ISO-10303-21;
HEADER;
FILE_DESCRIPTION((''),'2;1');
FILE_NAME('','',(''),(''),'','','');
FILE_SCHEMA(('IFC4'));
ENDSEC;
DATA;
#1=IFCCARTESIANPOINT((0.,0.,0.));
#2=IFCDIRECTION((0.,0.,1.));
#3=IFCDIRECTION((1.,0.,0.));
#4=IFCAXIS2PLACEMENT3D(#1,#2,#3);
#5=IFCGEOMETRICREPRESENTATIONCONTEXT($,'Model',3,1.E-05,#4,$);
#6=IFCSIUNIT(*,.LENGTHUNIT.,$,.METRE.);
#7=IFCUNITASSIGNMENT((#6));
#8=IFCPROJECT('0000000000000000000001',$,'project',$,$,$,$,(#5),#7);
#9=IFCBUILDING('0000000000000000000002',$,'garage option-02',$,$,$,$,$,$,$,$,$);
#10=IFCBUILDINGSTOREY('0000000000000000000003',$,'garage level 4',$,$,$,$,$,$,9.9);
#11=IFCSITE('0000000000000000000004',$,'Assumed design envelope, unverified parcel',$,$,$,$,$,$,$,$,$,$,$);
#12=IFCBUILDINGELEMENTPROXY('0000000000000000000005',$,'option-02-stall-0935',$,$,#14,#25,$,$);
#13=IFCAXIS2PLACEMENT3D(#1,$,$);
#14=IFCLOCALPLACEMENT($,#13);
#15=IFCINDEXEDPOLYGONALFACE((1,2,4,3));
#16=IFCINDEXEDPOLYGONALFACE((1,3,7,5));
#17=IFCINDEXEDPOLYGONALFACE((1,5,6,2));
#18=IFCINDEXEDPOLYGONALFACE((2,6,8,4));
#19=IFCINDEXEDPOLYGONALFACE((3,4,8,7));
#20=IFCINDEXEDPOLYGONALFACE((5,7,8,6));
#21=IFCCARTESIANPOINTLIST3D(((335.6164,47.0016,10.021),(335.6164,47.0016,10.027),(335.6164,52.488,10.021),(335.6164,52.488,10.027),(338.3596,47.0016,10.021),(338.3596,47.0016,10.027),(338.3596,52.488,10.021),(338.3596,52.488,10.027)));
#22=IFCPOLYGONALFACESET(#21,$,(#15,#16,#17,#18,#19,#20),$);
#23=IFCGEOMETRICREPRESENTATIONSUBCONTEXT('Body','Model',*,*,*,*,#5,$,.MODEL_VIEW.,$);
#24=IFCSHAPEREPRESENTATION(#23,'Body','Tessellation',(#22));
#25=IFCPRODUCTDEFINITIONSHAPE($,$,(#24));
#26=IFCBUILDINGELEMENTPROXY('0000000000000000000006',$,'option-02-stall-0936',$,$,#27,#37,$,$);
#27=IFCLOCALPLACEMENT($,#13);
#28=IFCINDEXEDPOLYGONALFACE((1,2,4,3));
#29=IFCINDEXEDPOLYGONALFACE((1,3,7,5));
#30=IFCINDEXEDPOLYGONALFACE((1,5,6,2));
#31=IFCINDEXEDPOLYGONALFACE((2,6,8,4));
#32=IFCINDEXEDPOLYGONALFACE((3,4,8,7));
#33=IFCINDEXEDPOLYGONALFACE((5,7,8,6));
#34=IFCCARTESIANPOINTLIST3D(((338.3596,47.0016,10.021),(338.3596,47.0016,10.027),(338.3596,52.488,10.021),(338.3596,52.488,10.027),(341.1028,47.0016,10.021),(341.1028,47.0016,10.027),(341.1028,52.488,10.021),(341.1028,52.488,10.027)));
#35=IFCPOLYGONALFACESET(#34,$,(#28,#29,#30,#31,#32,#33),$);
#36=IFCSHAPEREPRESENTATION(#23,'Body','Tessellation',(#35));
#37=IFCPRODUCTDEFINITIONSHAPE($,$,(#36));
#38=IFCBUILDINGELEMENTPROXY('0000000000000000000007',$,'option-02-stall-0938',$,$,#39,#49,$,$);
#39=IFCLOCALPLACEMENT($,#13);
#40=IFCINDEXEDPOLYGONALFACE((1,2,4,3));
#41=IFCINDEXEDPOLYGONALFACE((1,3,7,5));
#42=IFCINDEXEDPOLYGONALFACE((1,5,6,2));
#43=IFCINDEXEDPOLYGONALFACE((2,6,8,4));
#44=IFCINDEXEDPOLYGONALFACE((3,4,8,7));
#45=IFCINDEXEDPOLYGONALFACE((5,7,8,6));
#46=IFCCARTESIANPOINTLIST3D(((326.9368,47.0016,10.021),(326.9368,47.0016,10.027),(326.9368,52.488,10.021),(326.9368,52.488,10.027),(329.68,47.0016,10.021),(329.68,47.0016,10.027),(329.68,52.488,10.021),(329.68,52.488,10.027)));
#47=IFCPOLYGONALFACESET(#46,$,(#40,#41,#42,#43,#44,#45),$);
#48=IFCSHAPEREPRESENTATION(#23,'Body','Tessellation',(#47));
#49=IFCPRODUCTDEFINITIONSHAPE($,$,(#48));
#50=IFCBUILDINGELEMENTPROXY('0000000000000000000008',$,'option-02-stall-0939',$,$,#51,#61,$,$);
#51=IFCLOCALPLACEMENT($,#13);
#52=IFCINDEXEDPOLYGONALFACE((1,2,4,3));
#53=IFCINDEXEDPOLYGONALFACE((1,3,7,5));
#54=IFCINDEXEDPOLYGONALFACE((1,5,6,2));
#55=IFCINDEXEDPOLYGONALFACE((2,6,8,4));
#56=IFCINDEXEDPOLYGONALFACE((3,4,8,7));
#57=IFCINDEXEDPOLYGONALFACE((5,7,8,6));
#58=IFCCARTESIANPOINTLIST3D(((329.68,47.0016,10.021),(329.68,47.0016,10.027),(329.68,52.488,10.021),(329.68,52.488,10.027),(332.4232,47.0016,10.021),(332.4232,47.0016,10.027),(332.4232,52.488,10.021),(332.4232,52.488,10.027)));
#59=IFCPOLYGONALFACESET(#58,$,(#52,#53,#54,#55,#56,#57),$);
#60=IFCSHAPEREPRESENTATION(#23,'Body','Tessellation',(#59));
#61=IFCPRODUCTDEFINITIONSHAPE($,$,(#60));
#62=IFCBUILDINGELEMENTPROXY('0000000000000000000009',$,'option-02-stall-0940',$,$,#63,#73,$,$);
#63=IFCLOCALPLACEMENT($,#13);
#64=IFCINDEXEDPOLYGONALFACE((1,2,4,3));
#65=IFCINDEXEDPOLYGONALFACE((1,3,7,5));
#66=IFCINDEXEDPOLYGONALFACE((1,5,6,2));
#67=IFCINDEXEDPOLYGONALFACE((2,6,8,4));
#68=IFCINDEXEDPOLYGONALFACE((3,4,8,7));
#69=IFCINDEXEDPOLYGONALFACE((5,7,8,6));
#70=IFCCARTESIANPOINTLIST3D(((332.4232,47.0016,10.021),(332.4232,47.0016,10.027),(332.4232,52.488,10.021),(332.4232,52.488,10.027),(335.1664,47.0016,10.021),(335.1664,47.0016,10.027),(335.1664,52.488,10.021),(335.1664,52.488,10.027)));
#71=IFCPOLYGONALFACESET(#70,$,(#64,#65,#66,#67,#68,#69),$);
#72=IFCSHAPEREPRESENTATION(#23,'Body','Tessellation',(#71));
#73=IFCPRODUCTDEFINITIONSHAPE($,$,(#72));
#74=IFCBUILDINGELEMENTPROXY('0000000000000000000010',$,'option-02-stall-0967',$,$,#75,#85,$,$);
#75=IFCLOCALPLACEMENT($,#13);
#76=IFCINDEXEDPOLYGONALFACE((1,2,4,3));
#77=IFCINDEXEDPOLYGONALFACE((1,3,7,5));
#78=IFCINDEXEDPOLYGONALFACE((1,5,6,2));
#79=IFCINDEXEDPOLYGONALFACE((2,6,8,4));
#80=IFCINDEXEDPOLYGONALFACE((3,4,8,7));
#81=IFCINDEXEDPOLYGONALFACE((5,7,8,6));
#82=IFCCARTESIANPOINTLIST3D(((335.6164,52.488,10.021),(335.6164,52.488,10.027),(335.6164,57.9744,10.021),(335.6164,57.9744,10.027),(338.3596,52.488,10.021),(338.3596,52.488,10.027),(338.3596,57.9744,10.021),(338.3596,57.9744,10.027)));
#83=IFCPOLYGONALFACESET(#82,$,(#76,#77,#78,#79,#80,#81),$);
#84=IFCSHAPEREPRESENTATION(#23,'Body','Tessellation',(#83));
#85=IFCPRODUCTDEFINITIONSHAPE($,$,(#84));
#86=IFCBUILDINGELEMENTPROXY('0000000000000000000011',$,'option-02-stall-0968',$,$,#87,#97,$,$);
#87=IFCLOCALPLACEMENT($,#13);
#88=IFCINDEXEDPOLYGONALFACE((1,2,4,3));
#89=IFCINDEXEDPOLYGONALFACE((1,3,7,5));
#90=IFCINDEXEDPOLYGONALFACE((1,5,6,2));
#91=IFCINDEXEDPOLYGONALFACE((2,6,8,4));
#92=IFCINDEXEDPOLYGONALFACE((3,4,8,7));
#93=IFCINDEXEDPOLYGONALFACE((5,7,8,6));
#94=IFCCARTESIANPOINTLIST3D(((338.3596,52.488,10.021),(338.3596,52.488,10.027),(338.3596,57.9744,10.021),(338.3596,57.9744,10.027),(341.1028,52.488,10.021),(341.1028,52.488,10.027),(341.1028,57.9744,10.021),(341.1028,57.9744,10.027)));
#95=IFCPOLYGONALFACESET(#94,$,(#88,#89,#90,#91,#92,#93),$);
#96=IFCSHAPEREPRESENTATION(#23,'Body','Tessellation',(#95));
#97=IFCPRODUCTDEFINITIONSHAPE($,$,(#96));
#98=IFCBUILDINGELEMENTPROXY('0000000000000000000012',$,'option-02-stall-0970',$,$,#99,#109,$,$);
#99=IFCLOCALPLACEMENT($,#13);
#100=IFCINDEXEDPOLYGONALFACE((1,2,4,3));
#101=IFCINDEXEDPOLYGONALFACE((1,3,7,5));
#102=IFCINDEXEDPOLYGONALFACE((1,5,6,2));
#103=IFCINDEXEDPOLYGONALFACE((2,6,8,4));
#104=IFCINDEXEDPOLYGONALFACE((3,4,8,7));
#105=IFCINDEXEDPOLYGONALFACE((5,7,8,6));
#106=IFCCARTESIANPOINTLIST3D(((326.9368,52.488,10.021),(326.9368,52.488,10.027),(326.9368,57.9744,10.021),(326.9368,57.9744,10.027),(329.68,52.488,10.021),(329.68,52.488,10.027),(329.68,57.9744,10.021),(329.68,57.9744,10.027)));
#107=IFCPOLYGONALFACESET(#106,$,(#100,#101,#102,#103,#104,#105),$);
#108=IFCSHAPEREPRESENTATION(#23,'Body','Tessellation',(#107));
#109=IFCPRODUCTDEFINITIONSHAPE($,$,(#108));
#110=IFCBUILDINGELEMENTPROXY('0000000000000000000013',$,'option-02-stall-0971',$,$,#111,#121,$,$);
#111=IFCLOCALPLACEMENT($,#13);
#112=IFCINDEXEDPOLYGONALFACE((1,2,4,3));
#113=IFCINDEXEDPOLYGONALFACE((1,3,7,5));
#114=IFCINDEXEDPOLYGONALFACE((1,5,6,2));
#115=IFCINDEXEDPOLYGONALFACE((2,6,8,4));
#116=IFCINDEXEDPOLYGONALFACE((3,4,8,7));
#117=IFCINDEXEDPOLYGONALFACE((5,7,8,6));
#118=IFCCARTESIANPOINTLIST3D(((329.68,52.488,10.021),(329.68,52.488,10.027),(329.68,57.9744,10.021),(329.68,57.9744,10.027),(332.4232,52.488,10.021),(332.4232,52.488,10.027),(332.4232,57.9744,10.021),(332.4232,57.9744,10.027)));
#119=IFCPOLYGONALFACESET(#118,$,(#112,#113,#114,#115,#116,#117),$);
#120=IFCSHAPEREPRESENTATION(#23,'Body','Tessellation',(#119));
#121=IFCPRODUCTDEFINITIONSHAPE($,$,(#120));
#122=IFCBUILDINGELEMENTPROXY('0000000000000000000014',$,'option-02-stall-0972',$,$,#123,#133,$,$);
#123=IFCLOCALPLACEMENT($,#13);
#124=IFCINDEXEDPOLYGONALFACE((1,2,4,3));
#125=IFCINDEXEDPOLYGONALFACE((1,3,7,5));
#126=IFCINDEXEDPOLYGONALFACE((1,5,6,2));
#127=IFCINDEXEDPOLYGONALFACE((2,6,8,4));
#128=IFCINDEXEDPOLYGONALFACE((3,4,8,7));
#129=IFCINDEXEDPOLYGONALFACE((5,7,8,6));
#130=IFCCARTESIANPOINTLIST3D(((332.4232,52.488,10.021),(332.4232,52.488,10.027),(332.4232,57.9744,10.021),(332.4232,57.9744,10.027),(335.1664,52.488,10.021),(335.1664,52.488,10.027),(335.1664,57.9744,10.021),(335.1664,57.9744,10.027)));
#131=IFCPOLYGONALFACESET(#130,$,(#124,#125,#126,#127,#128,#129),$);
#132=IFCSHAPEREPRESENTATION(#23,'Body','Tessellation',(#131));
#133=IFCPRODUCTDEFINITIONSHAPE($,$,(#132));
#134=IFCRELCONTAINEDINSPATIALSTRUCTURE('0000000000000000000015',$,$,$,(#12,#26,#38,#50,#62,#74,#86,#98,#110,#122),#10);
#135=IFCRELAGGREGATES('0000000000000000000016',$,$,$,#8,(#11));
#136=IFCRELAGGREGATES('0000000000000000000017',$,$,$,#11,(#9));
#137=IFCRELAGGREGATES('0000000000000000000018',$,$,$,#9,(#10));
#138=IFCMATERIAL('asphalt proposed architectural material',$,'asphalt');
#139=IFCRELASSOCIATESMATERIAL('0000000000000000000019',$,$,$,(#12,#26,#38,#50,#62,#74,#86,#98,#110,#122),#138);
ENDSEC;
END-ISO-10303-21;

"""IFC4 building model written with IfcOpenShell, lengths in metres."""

from ifc_helpers import new_model, si_unit, frame, origin_with_axes, place, context, subcontext, project, spatial, rectangle, extrude, material, element, save


model = new_model("IFC4")

# Units and contexts
model_context = context("Model", 3, precision=1e-05, world=origin_with_axes())
body_context = subcontext(model_context, "Body", "Model", "MODEL_VIEW")
ifc_project = project(units=[si_unit("LENGTHUNIT", "METRE")], contexts=[model_context])

# Site, building, storey
site = spatial("IfcSite", under=ifc_project, Name="Assumed design envelope, unverified parcel")
building = spatial("IfcBuilding", under=site, Name="garage option-02")
storey = spatial("IfcBuildingStorey", under=building, Name="garage level 4", Elevation=9.9)

# Building element proxies
ifc_material_1 = material(Name="asphalt proposed architectural material", Category="asphalt")
for number, where, z_axis, x_axis, name in (
    (1, (336.988, 49.7448, 10.021), (0.0, 0.0, 1.0), (1.0, 0.0, 0.0), "option-02-stall-0935"),
    (2, (339.7312, 49.7448, 10.021), (0.0, 0.0, 1.0), (1.0, 0.0, 0.0), "option-02-stall-0936"),
    (3, (328.3084, 49.7448, 10.021), (0.0, 0.0, 1.0), (1.0, 0.0, 0.0), "option-02-stall-0938"),
    (4, (331.0516, 49.7448, 10.021), (0.0, 0.0, 1.0), (1.0, 0.0, 0.0), "option-02-stall-0939"),
    (5, (333.7948, 49.7448, 10.021), (0.0, 0.0, 1.0), (1.0, 0.0, 0.0), "option-02-stall-0940"),
):
    element("IfcBuildingElementProxy", number, at=place(None, frame(where, z_axis=z_axis, x_axis=x_axis)), inside=storey, material=ifc_material_1, Name=name, context=body_context, shape_type="SweptSolid", body=[
        extrude(rectangle(XDim=2.7432, YDim=5.4864), origin_with_axes(), (0.0, 0.0, 1.0), 0.006),
    ])
for number, where, z_axis, x_axis, name in (
    (6, (336.988, 55.2312, 10.021), (0.0, 0.0, 1.0), (1.0, 0.0, 0.0), "option-02-stall-0967"),
    (7, (339.7312, 55.2312, 10.021), (0.0, 0.0, 1.0), (1.0, 0.0, 0.0), "option-02-stall-0968"),
    (8, (328.3084, 55.2312, 10.021), (0.0, 0.0, 1.0), (1.0, 0.0, 0.0), "option-02-stall-0970"),
    (9, (331.0516, 55.2312, 10.021), (0.0, 0.0, 1.0), (1.0, 0.0, 0.0), "option-02-stall-0971"),
    (10, (333.7948, 55.2312, 10.021), (0.0, 0.0, 1.0), (1.0, 0.0, 0.0), "option-02-stall-0972"),
):
    element("IfcBuildingElementProxy", number, at=place(None, frame(where, z_axis=z_axis, x_axis=x_axis)), inside=storey, material=ifc_material_1, Name=name, context=body_context, shape_type="SweptSolid", body=[
        extrude(rectangle(XDim=2.7432, YDim=5.4864), origin_with_axes(), (0.0, 0.0, 1.0), 0.006),
    ])

save(model, "model.ifc")
